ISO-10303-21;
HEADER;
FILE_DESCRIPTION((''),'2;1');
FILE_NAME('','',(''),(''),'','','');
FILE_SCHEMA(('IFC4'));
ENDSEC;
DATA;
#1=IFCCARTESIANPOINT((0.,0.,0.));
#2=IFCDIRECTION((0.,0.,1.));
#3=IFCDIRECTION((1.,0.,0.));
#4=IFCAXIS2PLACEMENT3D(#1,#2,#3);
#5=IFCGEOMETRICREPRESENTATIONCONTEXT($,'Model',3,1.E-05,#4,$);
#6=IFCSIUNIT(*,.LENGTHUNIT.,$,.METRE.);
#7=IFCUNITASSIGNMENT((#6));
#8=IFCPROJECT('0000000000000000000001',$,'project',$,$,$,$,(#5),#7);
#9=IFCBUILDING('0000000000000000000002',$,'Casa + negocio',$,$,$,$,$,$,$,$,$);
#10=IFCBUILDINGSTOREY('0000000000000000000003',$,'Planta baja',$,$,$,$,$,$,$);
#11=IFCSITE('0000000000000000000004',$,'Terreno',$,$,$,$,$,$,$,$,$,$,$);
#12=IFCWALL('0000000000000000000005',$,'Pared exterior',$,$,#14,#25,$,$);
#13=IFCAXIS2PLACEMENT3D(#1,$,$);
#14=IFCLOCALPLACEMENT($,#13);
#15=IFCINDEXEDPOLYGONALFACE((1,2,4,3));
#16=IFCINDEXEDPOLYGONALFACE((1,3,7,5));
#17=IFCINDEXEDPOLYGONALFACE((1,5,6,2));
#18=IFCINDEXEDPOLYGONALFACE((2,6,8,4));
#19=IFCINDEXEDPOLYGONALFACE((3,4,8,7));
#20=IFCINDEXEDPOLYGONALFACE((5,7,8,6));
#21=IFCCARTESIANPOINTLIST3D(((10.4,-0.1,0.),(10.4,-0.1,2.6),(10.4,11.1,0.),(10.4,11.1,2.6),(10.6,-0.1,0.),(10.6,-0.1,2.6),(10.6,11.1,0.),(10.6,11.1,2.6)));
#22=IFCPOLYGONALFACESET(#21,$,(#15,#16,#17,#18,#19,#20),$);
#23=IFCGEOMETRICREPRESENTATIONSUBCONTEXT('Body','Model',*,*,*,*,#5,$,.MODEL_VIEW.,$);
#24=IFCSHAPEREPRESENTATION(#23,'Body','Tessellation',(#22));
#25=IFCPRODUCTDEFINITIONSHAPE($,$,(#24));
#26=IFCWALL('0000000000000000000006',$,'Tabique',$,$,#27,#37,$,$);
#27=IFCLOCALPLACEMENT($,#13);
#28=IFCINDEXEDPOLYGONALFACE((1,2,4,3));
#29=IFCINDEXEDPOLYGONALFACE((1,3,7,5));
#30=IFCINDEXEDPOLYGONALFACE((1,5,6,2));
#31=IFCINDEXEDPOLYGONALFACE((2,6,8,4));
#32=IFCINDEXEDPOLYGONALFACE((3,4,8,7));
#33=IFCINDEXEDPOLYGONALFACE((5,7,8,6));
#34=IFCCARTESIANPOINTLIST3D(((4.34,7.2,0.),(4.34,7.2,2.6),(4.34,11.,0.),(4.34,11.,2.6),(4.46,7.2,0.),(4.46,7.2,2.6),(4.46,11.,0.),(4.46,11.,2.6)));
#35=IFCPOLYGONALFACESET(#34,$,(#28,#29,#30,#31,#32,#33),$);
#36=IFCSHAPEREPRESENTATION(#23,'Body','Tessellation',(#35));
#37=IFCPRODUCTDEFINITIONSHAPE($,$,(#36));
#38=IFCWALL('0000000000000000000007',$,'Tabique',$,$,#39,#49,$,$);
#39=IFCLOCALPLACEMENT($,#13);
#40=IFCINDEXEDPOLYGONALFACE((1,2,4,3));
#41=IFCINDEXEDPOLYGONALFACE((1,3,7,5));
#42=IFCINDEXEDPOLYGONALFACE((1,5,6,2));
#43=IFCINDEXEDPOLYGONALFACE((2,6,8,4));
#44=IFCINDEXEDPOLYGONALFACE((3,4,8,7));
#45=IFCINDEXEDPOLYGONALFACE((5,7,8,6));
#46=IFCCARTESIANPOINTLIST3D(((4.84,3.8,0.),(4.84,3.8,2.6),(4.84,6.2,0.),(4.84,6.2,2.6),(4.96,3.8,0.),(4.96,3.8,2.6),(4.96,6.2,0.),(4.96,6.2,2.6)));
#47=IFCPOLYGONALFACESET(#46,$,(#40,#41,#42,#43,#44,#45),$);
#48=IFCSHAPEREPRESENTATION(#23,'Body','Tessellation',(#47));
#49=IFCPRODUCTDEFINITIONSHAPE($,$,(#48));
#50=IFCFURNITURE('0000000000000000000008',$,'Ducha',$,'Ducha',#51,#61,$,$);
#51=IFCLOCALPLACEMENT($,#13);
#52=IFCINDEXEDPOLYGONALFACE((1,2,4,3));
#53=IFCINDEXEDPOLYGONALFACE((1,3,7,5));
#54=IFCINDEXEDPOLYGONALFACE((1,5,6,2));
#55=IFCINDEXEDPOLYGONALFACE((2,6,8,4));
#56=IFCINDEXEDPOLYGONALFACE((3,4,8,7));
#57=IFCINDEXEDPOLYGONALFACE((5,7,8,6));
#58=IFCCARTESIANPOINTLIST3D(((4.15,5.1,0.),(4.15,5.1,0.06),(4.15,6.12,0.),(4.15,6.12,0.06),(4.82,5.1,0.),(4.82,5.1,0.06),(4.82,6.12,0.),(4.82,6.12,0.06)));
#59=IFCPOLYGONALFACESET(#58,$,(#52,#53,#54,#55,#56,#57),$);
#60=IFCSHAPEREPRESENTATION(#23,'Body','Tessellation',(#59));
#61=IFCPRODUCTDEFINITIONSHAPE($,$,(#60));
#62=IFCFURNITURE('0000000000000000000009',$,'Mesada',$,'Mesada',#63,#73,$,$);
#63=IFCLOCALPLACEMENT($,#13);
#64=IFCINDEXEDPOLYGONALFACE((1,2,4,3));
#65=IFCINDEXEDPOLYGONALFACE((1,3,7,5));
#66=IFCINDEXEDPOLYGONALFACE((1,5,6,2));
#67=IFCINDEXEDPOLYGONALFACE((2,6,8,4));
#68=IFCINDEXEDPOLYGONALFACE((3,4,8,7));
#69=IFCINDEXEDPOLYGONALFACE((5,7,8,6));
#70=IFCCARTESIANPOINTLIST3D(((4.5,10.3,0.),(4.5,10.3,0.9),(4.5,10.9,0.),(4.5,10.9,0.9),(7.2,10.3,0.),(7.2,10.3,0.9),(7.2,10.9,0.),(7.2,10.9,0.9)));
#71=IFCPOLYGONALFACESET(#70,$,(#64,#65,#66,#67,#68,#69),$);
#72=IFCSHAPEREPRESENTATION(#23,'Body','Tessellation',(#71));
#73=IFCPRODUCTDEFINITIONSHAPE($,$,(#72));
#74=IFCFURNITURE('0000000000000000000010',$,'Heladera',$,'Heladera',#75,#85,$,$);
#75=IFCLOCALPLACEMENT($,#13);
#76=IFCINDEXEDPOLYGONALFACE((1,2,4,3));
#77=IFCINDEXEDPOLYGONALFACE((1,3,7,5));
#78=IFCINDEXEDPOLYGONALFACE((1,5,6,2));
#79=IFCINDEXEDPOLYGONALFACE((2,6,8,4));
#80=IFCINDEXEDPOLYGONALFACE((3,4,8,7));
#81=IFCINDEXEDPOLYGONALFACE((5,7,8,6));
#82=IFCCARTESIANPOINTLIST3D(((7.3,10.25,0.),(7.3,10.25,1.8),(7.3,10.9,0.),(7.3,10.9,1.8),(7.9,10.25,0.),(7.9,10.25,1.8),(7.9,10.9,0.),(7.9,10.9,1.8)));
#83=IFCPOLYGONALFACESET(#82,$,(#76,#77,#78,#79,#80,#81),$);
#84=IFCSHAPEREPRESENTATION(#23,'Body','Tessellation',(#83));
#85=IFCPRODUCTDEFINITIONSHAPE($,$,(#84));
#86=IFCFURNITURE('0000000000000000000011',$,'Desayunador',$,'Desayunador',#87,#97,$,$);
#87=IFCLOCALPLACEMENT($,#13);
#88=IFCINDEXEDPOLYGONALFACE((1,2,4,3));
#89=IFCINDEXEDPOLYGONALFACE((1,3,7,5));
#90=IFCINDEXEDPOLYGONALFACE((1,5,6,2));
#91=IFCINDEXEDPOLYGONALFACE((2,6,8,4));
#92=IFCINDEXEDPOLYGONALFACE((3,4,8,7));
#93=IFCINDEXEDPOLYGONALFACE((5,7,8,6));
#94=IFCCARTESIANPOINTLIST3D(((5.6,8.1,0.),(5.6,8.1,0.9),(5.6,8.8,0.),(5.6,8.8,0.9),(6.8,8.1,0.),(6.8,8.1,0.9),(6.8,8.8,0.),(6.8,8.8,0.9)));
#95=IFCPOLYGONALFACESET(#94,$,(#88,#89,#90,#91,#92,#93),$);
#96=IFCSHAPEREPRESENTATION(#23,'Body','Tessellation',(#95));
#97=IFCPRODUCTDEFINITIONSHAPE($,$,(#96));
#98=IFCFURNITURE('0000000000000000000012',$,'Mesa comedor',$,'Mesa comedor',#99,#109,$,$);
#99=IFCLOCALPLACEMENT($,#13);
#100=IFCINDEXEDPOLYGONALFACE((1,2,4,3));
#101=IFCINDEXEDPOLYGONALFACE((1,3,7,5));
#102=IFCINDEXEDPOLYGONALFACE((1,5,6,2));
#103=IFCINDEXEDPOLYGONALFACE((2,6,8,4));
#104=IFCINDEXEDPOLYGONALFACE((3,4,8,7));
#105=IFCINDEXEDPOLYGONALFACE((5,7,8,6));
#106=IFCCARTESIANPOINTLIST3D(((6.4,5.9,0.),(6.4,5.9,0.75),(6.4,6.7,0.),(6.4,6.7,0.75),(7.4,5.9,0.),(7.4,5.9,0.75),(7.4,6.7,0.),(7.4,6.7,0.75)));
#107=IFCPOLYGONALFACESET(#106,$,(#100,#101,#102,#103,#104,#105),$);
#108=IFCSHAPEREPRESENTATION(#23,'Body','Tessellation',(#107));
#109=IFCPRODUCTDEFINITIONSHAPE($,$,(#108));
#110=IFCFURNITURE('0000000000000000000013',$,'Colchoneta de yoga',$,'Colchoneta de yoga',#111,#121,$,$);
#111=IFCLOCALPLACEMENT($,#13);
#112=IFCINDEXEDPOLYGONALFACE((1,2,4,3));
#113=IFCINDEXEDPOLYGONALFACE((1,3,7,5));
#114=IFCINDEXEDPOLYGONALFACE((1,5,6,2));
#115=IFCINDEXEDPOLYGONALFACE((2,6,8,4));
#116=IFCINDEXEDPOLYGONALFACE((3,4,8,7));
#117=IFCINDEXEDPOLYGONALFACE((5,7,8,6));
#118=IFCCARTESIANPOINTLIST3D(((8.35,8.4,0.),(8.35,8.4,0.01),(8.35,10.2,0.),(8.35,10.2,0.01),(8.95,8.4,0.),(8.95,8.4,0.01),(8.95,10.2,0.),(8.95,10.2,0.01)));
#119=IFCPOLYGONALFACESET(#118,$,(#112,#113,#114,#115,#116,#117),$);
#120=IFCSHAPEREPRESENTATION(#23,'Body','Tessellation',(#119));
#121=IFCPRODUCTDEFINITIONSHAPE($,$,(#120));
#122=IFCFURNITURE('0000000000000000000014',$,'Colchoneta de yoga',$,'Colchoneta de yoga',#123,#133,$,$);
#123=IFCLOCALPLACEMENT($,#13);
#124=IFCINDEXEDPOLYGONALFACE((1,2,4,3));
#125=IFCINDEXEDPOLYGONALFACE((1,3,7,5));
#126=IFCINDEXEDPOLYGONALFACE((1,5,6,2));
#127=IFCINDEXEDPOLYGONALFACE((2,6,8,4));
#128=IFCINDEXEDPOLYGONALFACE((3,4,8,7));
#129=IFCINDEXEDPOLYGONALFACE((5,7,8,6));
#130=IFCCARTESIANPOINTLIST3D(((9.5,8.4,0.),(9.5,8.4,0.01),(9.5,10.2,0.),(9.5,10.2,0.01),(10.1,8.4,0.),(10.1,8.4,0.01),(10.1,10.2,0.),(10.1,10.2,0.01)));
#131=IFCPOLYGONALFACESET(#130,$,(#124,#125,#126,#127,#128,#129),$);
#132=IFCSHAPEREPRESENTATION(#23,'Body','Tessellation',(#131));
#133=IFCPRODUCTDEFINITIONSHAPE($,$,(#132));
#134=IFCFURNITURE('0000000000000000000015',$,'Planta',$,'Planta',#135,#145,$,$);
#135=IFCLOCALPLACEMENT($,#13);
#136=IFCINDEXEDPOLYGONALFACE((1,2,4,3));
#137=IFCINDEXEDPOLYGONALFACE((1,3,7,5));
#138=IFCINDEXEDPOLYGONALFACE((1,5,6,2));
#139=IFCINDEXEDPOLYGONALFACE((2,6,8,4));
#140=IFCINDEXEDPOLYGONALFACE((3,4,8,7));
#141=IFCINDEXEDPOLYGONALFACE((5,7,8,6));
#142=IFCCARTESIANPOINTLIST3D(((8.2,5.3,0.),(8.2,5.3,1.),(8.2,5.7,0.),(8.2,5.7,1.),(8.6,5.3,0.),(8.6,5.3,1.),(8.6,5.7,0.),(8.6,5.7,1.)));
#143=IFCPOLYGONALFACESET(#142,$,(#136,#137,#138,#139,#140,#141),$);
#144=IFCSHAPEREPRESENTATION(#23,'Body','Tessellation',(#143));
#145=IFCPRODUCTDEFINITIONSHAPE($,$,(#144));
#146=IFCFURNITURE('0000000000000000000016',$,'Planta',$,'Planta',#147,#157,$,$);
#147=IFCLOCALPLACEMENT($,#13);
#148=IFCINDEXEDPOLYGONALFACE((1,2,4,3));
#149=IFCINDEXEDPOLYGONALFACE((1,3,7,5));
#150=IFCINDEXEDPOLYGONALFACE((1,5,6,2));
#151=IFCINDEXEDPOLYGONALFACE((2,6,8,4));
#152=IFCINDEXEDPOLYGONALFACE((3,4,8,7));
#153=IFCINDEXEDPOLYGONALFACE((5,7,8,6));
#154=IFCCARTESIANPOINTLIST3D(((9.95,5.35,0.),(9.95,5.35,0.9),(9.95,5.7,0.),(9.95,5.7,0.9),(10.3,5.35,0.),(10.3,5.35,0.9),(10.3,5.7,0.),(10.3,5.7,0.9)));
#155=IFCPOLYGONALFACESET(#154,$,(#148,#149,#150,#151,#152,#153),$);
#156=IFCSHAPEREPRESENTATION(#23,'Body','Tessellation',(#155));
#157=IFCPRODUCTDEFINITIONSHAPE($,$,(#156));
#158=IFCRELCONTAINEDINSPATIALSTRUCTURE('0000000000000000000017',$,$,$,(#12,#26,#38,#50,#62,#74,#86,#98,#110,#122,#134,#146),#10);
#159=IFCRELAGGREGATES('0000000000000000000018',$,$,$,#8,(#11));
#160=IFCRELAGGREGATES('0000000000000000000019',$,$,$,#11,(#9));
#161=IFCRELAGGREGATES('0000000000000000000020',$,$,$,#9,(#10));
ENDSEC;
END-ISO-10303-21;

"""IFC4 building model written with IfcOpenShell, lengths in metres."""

from ifc_helpers import new_model, si_unit, frame, origin_with_axes, place, context, subcontext, project, spatial, line, indexed_curve, outline, extrude, element, save


model = new_model("IFC4")

# Units and contexts
model_context = context("Model", 3, precision=1e-05, world=origin_with_axes())
body_context = subcontext(model_context, "Body", "Model", "MODEL_VIEW")
ifc_project = project(units=[si_unit("LENGTHUNIT", "METRE")], contexts=[model_context])

# Site, building, storey
site = spatial("IfcSite", under=ifc_project, Name="Terreno")
building = spatial("IfcBuilding", under=site, Name="Casa + negocio")
storey = spatial("IfcBuildingStorey", under=building, Name="Planta baja")

# Wall
wall_1_placement = place(None, frame((10.5, 11.1, 0.0), z_axis=(0.0, 0.0, 1.0), x_axis=(0.0, -1.0, 0.0)))
element("IfcWall", 1, at=wall_1_placement, inside=storey, Name="Pared exterior", context=body_context, shape_type="SweptSolid", body=[
    extrude(outline(indexed_curve([(0.0, 0.0), (0.0, 0.2), (11.2, 0.2), (11.2, 0.0), (0.0, 0.0)], self_intersect=False)), frame((0.0, -0.1, 0.0), z_axis=(0.0, 0.0, 1.0), x_axis=(1.0, 0.0, 0.0)), (0.0, 0.0, 1.0), 2.6),
])

# Walls
wall_2_placement = place(None, frame((4.4, 11.0, 0.0), z_axis=(0.0, 0.0, 1.0), x_axis=(0.0, -1.0, 0.0)))
element("IfcWall", 2, at=wall_2_placement, inside=storey, Name="Tabique", context=body_context, shape_type="SweptSolid", body=[
    extrude(outline(indexed_curve([(0.0, 0.0), (0.0, 0.12), (3.8, 0.12), (3.8, 0.0), (0.0, 0.0)], self_intersect=False)), frame((0.0, -0.06, 0.0), z_axis=(0.0, 0.0, 1.0), x_axis=(1.0, 0.0, 0.0)), (0.0, 0.0, 1.0), 2.6),
])
wall_3_placement = place(None, frame((4.9, 6.2, 0.0), z_axis=(0.0, 0.0, 1.0), x_axis=(0.0, -1.0, 0.0)))
element("IfcWall", 3, at=wall_3_placement, inside=storey, Name="Tabique", context=body_context, shape_type="SweptSolid", body=[
    extrude(outline(indexed_curve([(0.0, 0.0), (0.0, 0.12), (2.4, 0.12), (2.4, 0.0), (0.0, 0.0)], self_intersect=False)), frame((0.0, -0.06, 0.0), z_axis=(0.0, 0.0, 1.0), x_axis=(1.0, 0.0, 0.0)), (0.0, 0.0, 1.0), 2.6),
])

# Furniture
furniture_1_placement = place(None, frame((4.15, 5.1, 0.0), z_axis=(0.0, 0.0, 1.0), x_axis=(1.0, 0.0, 0.0)))
element("IfcFurniture", 4, at=furniture_1_placement, inside=storey, Name="Ducha", ObjectType="Ducha", context=body_context, shape_type="SweptSolid", body=[
    extrude(outline(indexed_curve([(0.0, 0.0), (0.67, 0.0), (0.67, 1.02), (0.0, 1.02)], segments=[line(1, 2, 3, 4, 1)])), origin_with_axes(), (0.0, 0.0, 1.0), 0.06),
])
furniture_2_placement = place(None, frame((4.5, 10.3, 0.0), z_axis=(0.0, 0.0, 1.0), x_axis=(1.0, 0.0, 0.0)))
element("IfcFurniture", 5, at=furniture_2_placement, inside=storey, Name="Mesada", ObjectType="Mesada", context=body_context, shape_type="SweptSolid", body=[
    extrude(outline(indexed_curve([(0.0, 0.0), (2.7, 0.0), (2.7, 0.6), (0.0, 0.6)], segments=[line(1, 2, 3, 4, 1)])), origin_with_axes(), (0.0, 0.0, 1.0), 0.9),
])
furniture_3_placement = place(None, frame((7.3, 10.25, 0.0), z_axis=(0.0, 0.0, 1.0), x_axis=(1.0, 0.0, 0.0)))
element("IfcFurniture", 6, at=furniture_3_placement, inside=storey, Name="Heladera", ObjectType="Heladera", context=body_context, shape_type="SweptSolid", body=[
    extrude(outline(indexed_curve([(0.0, 0.0), (0.6, 0.0), (0.6, 0.65), (0.0, 0.65)], segments=[line(1, 2, 3, 4, 1)])), origin_with_axes(), (0.0, 0.0, 1.0), 1.8),
])
furniture_4_placement = place(None, frame((5.6, 8.1, 0.0), z_axis=(0.0, 0.0, 1.0), x_axis=(1.0, 0.0, 0.0)))
element("IfcFurniture", 7, at=furniture_4_placement, inside=storey, Name="Desayunador", ObjectType="Desayunador", context=body_context, shape_type="SweptSolid", body=[
    extrude(outline(indexed_curve([(0.0, 0.0), (1.2, 0.0), (1.2, 0.7), (0.0, 0.7)], segments=[line(1, 2, 3, 4, 1)])), origin_with_axes(), (0.0, 0.0, 1.0), 0.9),
])
furniture_5_placement = place(None, frame((6.4, 5.9, 0.0), z_axis=(0.0, 0.0, 1.0), x_axis=(1.0, 0.0, 0.0)))
element("IfcFurniture", 8, at=furniture_5_placement, inside=storey, Name="Mesa comedor", ObjectType="Mesa comedor", context=body_context, shape_type="SweptSolid", body=[
    extrude(outline(indexed_curve([(0.0, 0.0), (1.0, 0.0), (1.0, 0.8), (0.0, 0.8)], segments=[line(1, 2, 3, 4, 1)])), origin_with_axes(), (0.0, 0.0, 1.0), 0.75),
])
for number, where, z_axis, x_axis, name in (
    (9, (8.35, 8.4, 0.0), (0.0, 0.0, 1.0), (1.0, 0.0, 0.0), "Colchoneta de yoga"),
    (10, (9.5, 8.4, 0.0), (0.0, 0.0, 1.0), (1.0, 0.0, 0.0), "Colchoneta de yoga"),
):
    element("IfcFurniture", number, at=place(None, frame(where, z_axis=z_axis, x_axis=x_axis)), inside=storey, Name=name, ObjectType="Colchoneta de yoga", context=body_context, shape_type="SweptSolid", body=[
        extrude(outline(indexed_curve([(0.0, 0.0), (0.6, 0.0), (0.6, 1.8), (0.0, 1.8)], segments=[line(1, 2, 3, 4, 1)])), origin_with_axes(), (0.0, 0.0, 1.0), 0.01),
    ])
furniture_6_placement = place(None, frame((8.2, 5.3, 0.0), z_axis=(0.0, 0.0, 1.0), x_axis=(1.0, 0.0, 0.0)))
element("IfcFurniture", 11, at=furniture_6_placement, inside=storey, Name="Planta", ObjectType="Planta", context=body_context, shape_type="SweptSolid", body=[
    extrude(outline(indexed_curve([(0.0, 0.0), (0.4, 0.0), (0.4, 0.4), (0.0, 0.4)], segments=[line(1, 2, 3, 4, 1)])), origin_with_axes(), (0.0, 0.0, 1.0), 1.0),
])
furniture_7_placement = place(None, frame((9.95, 5.35, 0.0), z_axis=(0.0, 0.0, 1.0), x_axis=(1.0, 0.0, 0.0)))
element("IfcFurniture", 12, at=furniture_7_placement, inside=storey, Name="Planta", ObjectType="Planta", context=body_context, shape_type="SweptSolid", body=[
    extrude(outline(indexed_curve([(0.0, 0.0), (0.35, 0.0), (0.35, 0.35), (0.0, 0.35)], segments=[line(1, 2, 3, 4, 1)])), origin_with_axes(), (0.0, 0.0, 1.0), 0.9),
])

save(model, "model.ifc")
